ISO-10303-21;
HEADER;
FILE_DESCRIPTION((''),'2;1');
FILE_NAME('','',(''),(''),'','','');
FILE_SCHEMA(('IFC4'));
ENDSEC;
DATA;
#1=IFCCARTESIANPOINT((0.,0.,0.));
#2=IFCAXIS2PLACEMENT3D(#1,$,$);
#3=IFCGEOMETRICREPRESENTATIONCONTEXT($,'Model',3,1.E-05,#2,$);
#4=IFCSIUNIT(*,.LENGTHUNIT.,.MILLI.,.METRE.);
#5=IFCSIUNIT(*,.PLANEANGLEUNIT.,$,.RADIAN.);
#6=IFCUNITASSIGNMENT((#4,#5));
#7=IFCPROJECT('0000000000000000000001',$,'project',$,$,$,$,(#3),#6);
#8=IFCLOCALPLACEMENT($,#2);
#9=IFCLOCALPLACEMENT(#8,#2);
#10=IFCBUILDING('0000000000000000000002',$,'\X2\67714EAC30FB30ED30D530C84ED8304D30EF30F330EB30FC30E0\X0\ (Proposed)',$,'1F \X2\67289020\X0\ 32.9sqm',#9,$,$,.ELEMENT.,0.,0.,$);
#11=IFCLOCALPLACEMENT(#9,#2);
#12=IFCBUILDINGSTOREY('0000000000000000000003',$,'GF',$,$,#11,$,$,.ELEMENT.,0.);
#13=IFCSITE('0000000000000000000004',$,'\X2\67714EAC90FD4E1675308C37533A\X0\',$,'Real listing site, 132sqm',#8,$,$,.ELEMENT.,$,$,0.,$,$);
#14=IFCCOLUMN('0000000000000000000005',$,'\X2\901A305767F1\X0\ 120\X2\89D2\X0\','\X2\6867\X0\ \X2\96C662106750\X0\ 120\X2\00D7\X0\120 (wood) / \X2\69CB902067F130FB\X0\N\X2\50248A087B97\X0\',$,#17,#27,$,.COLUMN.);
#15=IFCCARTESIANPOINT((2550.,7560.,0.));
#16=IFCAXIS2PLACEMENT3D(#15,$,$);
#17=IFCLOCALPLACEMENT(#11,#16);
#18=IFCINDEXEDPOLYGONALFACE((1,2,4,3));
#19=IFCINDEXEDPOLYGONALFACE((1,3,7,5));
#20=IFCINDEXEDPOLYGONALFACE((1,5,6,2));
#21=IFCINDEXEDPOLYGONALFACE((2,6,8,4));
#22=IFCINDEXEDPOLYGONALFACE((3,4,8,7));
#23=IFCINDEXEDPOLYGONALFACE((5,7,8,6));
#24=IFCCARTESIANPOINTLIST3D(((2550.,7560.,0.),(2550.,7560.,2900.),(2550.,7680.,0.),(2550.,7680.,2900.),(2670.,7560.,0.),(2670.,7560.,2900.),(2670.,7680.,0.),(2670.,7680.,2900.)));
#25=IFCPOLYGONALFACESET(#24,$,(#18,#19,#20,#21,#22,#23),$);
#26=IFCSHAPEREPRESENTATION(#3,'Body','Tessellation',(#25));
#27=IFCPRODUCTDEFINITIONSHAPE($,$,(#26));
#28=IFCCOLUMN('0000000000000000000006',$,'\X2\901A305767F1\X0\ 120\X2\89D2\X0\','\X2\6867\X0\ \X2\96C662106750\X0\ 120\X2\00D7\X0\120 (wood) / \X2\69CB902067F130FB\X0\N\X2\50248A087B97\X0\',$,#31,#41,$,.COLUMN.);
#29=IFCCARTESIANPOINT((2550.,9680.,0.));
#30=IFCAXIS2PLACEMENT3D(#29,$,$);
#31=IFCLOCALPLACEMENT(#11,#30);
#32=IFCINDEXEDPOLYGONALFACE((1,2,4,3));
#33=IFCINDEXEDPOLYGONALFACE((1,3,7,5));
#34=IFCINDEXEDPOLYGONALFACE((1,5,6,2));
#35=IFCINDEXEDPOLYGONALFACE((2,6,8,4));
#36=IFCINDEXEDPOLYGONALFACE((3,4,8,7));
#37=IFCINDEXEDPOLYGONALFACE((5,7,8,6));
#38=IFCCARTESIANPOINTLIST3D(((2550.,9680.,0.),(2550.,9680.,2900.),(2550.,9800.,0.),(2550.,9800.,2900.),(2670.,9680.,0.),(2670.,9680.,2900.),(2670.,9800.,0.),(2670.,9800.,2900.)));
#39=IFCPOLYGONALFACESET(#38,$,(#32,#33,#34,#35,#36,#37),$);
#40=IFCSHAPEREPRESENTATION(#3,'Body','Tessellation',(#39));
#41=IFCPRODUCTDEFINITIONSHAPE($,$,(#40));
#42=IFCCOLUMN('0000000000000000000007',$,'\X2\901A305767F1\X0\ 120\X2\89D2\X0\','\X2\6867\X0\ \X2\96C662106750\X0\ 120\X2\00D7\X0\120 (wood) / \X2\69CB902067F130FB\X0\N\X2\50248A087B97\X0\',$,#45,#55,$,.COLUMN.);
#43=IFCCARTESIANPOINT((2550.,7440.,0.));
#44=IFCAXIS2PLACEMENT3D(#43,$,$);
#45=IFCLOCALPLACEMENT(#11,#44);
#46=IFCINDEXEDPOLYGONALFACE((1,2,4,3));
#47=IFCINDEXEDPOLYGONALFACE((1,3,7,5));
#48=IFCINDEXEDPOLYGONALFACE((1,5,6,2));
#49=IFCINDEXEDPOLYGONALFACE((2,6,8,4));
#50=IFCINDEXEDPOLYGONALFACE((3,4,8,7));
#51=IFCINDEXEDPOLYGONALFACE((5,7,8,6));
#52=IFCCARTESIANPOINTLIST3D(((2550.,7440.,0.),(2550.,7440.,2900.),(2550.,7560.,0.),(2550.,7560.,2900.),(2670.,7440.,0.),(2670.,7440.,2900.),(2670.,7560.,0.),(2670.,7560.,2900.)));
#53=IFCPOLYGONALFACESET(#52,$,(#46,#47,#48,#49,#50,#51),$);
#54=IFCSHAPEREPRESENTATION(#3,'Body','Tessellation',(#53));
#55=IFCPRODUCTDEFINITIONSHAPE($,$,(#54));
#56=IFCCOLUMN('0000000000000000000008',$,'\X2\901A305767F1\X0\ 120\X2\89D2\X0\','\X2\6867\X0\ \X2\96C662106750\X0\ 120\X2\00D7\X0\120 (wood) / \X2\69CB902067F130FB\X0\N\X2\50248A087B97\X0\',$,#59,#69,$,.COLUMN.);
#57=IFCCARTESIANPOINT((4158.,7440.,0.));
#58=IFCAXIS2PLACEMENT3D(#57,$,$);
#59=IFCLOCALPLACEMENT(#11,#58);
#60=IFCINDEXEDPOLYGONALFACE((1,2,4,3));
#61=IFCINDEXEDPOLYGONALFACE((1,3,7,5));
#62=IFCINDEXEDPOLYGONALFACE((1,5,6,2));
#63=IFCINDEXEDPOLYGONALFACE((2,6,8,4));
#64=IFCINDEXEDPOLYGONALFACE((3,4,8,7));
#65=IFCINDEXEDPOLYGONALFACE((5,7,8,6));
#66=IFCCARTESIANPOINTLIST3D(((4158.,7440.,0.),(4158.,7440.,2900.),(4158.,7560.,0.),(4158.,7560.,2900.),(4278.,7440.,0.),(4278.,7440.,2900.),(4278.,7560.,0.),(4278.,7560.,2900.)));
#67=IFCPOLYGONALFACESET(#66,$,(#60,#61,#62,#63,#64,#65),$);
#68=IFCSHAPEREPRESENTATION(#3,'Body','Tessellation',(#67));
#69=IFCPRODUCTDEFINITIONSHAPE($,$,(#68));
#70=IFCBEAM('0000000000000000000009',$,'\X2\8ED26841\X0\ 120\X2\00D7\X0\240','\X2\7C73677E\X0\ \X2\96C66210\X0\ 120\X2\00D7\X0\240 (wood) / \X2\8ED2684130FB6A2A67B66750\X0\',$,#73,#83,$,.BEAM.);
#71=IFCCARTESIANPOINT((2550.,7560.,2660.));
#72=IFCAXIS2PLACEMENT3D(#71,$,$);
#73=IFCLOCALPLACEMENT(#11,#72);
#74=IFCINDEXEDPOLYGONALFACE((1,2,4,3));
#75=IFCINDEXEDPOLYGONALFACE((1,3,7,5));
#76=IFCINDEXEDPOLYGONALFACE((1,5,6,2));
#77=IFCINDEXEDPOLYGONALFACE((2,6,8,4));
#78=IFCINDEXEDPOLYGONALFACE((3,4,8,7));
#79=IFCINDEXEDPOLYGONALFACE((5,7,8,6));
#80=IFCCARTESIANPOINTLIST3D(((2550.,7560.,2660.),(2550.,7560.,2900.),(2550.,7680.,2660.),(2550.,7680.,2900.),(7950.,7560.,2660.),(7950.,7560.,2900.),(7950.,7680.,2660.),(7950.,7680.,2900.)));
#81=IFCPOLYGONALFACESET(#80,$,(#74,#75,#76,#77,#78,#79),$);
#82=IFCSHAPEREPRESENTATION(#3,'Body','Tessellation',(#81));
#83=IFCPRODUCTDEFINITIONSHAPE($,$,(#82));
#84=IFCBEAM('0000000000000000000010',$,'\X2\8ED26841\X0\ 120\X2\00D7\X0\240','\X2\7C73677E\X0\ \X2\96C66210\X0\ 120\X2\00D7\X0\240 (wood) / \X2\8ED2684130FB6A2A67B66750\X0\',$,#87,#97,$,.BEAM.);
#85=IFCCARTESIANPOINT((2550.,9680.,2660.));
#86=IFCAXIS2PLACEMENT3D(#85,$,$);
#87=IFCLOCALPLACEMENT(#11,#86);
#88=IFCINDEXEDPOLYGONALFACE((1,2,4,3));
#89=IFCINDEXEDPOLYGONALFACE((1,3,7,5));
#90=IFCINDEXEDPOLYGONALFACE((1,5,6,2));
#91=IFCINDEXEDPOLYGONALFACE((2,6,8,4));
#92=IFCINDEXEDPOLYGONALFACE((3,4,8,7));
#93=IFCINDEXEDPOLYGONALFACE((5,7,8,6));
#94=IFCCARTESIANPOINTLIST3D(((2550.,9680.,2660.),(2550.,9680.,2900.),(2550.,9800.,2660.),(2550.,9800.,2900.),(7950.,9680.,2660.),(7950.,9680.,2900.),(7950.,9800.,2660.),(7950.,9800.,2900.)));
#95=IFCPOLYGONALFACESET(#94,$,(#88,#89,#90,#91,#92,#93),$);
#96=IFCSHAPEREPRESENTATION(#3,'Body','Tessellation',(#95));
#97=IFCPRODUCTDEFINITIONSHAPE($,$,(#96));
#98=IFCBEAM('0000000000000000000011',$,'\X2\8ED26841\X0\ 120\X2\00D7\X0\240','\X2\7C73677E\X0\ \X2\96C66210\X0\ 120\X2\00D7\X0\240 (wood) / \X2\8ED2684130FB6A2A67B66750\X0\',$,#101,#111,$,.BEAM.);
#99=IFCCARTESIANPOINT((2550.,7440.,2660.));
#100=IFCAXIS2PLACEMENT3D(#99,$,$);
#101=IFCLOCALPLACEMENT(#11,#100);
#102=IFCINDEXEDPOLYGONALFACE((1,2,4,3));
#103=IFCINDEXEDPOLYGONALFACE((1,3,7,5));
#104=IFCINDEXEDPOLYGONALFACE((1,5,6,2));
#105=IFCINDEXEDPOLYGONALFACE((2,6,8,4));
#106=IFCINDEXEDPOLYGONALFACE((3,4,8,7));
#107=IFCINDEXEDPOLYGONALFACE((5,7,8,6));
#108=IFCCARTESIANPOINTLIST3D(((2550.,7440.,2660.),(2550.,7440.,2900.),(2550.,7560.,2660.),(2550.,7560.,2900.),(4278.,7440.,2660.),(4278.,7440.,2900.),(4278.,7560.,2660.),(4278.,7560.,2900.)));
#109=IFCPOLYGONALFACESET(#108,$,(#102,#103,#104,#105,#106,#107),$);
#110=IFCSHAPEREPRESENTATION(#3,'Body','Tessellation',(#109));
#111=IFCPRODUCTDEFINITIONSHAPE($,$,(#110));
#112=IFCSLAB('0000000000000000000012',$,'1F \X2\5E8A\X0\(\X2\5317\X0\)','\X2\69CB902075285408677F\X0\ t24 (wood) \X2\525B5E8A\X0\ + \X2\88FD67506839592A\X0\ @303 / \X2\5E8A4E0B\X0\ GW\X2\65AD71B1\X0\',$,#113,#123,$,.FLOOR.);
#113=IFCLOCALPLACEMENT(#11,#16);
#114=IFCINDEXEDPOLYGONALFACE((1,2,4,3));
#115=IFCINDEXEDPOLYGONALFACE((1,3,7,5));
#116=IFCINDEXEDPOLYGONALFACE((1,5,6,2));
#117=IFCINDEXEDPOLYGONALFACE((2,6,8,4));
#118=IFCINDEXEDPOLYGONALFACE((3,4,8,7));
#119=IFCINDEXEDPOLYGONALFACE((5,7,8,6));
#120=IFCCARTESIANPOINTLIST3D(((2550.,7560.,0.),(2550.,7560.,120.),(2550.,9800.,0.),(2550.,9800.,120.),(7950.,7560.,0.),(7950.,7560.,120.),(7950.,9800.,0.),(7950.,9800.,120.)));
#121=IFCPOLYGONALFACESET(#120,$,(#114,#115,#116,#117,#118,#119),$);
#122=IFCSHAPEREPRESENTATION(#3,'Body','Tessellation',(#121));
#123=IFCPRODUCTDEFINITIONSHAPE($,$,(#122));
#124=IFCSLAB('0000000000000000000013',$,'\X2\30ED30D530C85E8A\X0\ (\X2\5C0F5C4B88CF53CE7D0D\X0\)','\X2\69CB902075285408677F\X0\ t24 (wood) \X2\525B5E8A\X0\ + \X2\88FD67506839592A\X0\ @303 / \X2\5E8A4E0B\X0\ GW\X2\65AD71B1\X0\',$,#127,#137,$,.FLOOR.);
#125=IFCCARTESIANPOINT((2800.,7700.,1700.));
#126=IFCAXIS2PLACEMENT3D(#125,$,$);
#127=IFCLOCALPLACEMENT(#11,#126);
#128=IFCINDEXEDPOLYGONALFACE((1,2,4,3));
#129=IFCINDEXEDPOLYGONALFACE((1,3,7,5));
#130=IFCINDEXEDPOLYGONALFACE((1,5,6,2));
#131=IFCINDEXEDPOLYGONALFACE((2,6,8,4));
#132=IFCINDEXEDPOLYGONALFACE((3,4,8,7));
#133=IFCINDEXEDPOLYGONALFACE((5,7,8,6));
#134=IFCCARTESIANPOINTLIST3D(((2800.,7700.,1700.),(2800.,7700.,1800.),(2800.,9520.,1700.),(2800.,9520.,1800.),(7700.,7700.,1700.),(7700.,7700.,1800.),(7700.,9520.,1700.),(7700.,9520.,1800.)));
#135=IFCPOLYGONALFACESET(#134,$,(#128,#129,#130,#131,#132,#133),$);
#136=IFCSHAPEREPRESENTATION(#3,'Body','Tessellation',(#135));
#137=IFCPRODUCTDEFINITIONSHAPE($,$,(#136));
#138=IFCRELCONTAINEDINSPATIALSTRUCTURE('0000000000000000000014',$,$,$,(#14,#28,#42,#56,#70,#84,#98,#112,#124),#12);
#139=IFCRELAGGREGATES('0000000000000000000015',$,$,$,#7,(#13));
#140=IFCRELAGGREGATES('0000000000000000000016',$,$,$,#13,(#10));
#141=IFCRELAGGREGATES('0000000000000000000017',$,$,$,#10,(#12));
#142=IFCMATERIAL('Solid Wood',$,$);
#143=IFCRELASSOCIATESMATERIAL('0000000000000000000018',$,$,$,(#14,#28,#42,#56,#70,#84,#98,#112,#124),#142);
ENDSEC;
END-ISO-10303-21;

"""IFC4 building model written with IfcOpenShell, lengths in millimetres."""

from ifc_helpers import new_model, si_unit, frame, frame_2d, origin, place, context, project, spatial, rectangle, extrude, material, element, save


model = new_model("IFC4")

# Units and contexts
model_context = context("Model", 3, precision=1e-05, world=origin())
ifc_project = project(units=[si_unit("LENGTHUNIT", "METRE", prefix="MILLI"), si_unit("PLANEANGLEUNIT", "RADIAN")], contexts=[model_context])

# Site, building, storey
site_placement = place(None, origin())
site = spatial("IfcSite", under=ifc_project, at=site_placement, Name="東京都世田谷区", ObjectType="Real listing site, 132sqm", CompositionType="ELEMENT", RefElevation=0.0)
building_placement = place(site_placement, origin())
building = spatial("IfcBuilding", under=site, at=building_placement, Name="東京・ロフト付きワンルーム (Proposed)", ObjectType="1F 木造 32.9sqm", CompositionType="ELEMENT", ElevationOfRefHeight=0.0, ElevationOfTerrain=0.0)
storey_placement = place(building_placement, origin())
storey = spatial("IfcBuildingStorey", under=building, at=storey_placement, Name="GF", CompositionType="ELEMENT", Elevation=0.0)

# Columns
ifc_material_1 = material(Name="Solid Wood")
column_1_placement = place(storey_placement, frame((2550.0, 7560.0, 0.0)))
element("IfcColumn", 1, at=column_1_placement, inside=storey, material=ifc_material_1, Name="通し柱 120角", Description="桧 集成材 120×120 (wood) / 構造柱・N値計算", PredefinedType="COLUMN", context=model_context, shape_type="SweptSolid", body=[
    extrude(rectangle(XDim=120.0, YDim=120.0, at=frame_2d((60.0, 60.0))), frame((2550.0, 7560.0, 0.0)), (0.0, 0.0, 1.0), 2900.0),
])
column_2_placement = place(storey_placement, frame((2550.0, 9680.0, 0.0)))
element("IfcColumn", 2, at=column_2_placement, inside=storey, material=ifc_material_1, Name="通し柱 120角", Description="桧 集成材 120×120 (wood) / 構造柱・N値計算", PredefinedType="COLUMN", context=model_context, shape_type="SweptSolid", body=[
    extrude(rectangle(XDim=120.0, YDim=120.0, at=frame_2d((60.0, 60.0))), frame((2550.0, 9680.0, 0.0)), (0.0, 0.0, 1.0), 2900.0),
])
column_3_placement = place(storey_placement, frame((2550.0, 7440.0, 0.0)))
element("IfcColumn", 3, at=column_3_placement, inside=storey, material=ifc_material_1, Name="通し柱 120角", Description="桧 集成材 120×120 (wood) / 構造柱・N値計算", PredefinedType="COLUMN", context=model_context, shape_type="SweptSolid", body=[
    extrude(rectangle(XDim=120.0, YDim=120.0, at=frame_2d((60.0, 60.0))), frame((2550.0, 7440.0, 0.0)), (0.0, 0.0, 1.0), 2900.0),
])
column_4_placement = place(storey_placement, frame((4158.0, 7440.0, 0.0)))
element("IfcColumn", 4, at=column_4_placement, inside=storey, material=ifc_material_1, Name="通し柱 120角", Description="桧 集成材 120×120 (wood) / 構造柱・N値計算", PredefinedType="COLUMN", context=model_context, shape_type="SweptSolid", body=[
    extrude(rectangle(XDim=120.0, YDim=120.0, at=frame_2d((60.0, 60.0))), frame((4158.0, 7440.0, 0.0)), (0.0, 0.0, 1.0), 2900.0),
])

# Beams
beam_1_placement = place(storey_placement, frame((2550.0, 7560.0, 2660.0)))
element("IfcBeam", 5, at=beam_1_placement, inside=storey, material=ifc_material_1, Name="軒桁 120×240", Description="米松 集成 120×240 (wood) / 軒桁・横架材", PredefinedType="BEAM", context=model_context, shape_type="SweptSolid", body=[
    extrude(rectangle(XDim=5400.0, YDim=120.0, at=frame_2d((2700.0, 60.0))), frame((2550.0, 7560.0, 2660.0)), (0.0, 0.0, 1.0), 240.0),
])
beam_2_placement = place(storey_placement, frame((2550.0, 9680.0, 2660.0)))
element("IfcBeam", 6, at=beam_2_placement, inside=storey, material=ifc_material_1, Name="軒桁 120×240", Description="米松 集成 120×240 (wood) / 軒桁・横架材", PredefinedType="BEAM", context=model_context, shape_type="SweptSolid", body=[
    extrude(rectangle(XDim=5400.0, YDim=120.0, at=frame_2d((2700.0, 60.0))), frame((2550.0, 9680.0, 2660.0)), (0.0, 0.0, 1.0), 240.0),
])
beam_3_placement = place(storey_placement, frame((2550.0, 7440.0, 2660.0)))
element("IfcBeam", 7, at=beam_3_placement, inside=storey, material=ifc_material_1, Name="軒桁 120×240", Description="米松 集成 120×240 (wood) / 軒桁・横架材", PredefinedType="BEAM", context=model_context, shape_type="SweptSolid", body=[
    extrude(rectangle(XDim=1728.0, YDim=120.0, at=frame_2d((864.0, 60.0))), frame((2550.0, 7440.0, 2660.0)), (0.0, 0.0, 1.0), 240.0),
])

# Slabs
slab_1_placement = place(storey_placement, frame((2550.0, 7560.0, 0.0)))
element("IfcSlab", 8, at=slab_1_placement, inside=storey, material=ifc_material_1, Name="1F 床(北)", Description="構造用合板 t24 (wood) 剛床 + 製材根太 @303 / 床下 GW断熱", PredefinedType="FLOOR", context=model_context, shape_type="SweptSolid", body=[
    extrude(rectangle(XDim=5400.0, YDim=2240.0, at=frame_2d((2700.0, 1120.0))), frame((2550.0, 7560.0, 0.0)), (0.0, 0.0, 1.0), 120.0),
])
slab_2_placement = place(storey_placement, frame((2800.0, 7700.0, 1700.0)))
element("IfcSlab", 9, at=slab_2_placement, inside=storey, material=ifc_material_1, Name="ロフト床 (小屋裏収納)", Description="構造用合板 t24 (wood) 剛床 + 製材根太 @303 / 床下 GW断熱", PredefinedType="FLOOR", context=model_context, shape_type="SweptSolid", body=[
    extrude(rectangle(XDim=4900.0, YDim=1820.0, at=frame_2d((2450.0, 910.0))), frame((2800.0, 7700.0, 1700.0)), (0.0, 0.0, 1.0), 100.0),
])

save(model, "model.ifc")
